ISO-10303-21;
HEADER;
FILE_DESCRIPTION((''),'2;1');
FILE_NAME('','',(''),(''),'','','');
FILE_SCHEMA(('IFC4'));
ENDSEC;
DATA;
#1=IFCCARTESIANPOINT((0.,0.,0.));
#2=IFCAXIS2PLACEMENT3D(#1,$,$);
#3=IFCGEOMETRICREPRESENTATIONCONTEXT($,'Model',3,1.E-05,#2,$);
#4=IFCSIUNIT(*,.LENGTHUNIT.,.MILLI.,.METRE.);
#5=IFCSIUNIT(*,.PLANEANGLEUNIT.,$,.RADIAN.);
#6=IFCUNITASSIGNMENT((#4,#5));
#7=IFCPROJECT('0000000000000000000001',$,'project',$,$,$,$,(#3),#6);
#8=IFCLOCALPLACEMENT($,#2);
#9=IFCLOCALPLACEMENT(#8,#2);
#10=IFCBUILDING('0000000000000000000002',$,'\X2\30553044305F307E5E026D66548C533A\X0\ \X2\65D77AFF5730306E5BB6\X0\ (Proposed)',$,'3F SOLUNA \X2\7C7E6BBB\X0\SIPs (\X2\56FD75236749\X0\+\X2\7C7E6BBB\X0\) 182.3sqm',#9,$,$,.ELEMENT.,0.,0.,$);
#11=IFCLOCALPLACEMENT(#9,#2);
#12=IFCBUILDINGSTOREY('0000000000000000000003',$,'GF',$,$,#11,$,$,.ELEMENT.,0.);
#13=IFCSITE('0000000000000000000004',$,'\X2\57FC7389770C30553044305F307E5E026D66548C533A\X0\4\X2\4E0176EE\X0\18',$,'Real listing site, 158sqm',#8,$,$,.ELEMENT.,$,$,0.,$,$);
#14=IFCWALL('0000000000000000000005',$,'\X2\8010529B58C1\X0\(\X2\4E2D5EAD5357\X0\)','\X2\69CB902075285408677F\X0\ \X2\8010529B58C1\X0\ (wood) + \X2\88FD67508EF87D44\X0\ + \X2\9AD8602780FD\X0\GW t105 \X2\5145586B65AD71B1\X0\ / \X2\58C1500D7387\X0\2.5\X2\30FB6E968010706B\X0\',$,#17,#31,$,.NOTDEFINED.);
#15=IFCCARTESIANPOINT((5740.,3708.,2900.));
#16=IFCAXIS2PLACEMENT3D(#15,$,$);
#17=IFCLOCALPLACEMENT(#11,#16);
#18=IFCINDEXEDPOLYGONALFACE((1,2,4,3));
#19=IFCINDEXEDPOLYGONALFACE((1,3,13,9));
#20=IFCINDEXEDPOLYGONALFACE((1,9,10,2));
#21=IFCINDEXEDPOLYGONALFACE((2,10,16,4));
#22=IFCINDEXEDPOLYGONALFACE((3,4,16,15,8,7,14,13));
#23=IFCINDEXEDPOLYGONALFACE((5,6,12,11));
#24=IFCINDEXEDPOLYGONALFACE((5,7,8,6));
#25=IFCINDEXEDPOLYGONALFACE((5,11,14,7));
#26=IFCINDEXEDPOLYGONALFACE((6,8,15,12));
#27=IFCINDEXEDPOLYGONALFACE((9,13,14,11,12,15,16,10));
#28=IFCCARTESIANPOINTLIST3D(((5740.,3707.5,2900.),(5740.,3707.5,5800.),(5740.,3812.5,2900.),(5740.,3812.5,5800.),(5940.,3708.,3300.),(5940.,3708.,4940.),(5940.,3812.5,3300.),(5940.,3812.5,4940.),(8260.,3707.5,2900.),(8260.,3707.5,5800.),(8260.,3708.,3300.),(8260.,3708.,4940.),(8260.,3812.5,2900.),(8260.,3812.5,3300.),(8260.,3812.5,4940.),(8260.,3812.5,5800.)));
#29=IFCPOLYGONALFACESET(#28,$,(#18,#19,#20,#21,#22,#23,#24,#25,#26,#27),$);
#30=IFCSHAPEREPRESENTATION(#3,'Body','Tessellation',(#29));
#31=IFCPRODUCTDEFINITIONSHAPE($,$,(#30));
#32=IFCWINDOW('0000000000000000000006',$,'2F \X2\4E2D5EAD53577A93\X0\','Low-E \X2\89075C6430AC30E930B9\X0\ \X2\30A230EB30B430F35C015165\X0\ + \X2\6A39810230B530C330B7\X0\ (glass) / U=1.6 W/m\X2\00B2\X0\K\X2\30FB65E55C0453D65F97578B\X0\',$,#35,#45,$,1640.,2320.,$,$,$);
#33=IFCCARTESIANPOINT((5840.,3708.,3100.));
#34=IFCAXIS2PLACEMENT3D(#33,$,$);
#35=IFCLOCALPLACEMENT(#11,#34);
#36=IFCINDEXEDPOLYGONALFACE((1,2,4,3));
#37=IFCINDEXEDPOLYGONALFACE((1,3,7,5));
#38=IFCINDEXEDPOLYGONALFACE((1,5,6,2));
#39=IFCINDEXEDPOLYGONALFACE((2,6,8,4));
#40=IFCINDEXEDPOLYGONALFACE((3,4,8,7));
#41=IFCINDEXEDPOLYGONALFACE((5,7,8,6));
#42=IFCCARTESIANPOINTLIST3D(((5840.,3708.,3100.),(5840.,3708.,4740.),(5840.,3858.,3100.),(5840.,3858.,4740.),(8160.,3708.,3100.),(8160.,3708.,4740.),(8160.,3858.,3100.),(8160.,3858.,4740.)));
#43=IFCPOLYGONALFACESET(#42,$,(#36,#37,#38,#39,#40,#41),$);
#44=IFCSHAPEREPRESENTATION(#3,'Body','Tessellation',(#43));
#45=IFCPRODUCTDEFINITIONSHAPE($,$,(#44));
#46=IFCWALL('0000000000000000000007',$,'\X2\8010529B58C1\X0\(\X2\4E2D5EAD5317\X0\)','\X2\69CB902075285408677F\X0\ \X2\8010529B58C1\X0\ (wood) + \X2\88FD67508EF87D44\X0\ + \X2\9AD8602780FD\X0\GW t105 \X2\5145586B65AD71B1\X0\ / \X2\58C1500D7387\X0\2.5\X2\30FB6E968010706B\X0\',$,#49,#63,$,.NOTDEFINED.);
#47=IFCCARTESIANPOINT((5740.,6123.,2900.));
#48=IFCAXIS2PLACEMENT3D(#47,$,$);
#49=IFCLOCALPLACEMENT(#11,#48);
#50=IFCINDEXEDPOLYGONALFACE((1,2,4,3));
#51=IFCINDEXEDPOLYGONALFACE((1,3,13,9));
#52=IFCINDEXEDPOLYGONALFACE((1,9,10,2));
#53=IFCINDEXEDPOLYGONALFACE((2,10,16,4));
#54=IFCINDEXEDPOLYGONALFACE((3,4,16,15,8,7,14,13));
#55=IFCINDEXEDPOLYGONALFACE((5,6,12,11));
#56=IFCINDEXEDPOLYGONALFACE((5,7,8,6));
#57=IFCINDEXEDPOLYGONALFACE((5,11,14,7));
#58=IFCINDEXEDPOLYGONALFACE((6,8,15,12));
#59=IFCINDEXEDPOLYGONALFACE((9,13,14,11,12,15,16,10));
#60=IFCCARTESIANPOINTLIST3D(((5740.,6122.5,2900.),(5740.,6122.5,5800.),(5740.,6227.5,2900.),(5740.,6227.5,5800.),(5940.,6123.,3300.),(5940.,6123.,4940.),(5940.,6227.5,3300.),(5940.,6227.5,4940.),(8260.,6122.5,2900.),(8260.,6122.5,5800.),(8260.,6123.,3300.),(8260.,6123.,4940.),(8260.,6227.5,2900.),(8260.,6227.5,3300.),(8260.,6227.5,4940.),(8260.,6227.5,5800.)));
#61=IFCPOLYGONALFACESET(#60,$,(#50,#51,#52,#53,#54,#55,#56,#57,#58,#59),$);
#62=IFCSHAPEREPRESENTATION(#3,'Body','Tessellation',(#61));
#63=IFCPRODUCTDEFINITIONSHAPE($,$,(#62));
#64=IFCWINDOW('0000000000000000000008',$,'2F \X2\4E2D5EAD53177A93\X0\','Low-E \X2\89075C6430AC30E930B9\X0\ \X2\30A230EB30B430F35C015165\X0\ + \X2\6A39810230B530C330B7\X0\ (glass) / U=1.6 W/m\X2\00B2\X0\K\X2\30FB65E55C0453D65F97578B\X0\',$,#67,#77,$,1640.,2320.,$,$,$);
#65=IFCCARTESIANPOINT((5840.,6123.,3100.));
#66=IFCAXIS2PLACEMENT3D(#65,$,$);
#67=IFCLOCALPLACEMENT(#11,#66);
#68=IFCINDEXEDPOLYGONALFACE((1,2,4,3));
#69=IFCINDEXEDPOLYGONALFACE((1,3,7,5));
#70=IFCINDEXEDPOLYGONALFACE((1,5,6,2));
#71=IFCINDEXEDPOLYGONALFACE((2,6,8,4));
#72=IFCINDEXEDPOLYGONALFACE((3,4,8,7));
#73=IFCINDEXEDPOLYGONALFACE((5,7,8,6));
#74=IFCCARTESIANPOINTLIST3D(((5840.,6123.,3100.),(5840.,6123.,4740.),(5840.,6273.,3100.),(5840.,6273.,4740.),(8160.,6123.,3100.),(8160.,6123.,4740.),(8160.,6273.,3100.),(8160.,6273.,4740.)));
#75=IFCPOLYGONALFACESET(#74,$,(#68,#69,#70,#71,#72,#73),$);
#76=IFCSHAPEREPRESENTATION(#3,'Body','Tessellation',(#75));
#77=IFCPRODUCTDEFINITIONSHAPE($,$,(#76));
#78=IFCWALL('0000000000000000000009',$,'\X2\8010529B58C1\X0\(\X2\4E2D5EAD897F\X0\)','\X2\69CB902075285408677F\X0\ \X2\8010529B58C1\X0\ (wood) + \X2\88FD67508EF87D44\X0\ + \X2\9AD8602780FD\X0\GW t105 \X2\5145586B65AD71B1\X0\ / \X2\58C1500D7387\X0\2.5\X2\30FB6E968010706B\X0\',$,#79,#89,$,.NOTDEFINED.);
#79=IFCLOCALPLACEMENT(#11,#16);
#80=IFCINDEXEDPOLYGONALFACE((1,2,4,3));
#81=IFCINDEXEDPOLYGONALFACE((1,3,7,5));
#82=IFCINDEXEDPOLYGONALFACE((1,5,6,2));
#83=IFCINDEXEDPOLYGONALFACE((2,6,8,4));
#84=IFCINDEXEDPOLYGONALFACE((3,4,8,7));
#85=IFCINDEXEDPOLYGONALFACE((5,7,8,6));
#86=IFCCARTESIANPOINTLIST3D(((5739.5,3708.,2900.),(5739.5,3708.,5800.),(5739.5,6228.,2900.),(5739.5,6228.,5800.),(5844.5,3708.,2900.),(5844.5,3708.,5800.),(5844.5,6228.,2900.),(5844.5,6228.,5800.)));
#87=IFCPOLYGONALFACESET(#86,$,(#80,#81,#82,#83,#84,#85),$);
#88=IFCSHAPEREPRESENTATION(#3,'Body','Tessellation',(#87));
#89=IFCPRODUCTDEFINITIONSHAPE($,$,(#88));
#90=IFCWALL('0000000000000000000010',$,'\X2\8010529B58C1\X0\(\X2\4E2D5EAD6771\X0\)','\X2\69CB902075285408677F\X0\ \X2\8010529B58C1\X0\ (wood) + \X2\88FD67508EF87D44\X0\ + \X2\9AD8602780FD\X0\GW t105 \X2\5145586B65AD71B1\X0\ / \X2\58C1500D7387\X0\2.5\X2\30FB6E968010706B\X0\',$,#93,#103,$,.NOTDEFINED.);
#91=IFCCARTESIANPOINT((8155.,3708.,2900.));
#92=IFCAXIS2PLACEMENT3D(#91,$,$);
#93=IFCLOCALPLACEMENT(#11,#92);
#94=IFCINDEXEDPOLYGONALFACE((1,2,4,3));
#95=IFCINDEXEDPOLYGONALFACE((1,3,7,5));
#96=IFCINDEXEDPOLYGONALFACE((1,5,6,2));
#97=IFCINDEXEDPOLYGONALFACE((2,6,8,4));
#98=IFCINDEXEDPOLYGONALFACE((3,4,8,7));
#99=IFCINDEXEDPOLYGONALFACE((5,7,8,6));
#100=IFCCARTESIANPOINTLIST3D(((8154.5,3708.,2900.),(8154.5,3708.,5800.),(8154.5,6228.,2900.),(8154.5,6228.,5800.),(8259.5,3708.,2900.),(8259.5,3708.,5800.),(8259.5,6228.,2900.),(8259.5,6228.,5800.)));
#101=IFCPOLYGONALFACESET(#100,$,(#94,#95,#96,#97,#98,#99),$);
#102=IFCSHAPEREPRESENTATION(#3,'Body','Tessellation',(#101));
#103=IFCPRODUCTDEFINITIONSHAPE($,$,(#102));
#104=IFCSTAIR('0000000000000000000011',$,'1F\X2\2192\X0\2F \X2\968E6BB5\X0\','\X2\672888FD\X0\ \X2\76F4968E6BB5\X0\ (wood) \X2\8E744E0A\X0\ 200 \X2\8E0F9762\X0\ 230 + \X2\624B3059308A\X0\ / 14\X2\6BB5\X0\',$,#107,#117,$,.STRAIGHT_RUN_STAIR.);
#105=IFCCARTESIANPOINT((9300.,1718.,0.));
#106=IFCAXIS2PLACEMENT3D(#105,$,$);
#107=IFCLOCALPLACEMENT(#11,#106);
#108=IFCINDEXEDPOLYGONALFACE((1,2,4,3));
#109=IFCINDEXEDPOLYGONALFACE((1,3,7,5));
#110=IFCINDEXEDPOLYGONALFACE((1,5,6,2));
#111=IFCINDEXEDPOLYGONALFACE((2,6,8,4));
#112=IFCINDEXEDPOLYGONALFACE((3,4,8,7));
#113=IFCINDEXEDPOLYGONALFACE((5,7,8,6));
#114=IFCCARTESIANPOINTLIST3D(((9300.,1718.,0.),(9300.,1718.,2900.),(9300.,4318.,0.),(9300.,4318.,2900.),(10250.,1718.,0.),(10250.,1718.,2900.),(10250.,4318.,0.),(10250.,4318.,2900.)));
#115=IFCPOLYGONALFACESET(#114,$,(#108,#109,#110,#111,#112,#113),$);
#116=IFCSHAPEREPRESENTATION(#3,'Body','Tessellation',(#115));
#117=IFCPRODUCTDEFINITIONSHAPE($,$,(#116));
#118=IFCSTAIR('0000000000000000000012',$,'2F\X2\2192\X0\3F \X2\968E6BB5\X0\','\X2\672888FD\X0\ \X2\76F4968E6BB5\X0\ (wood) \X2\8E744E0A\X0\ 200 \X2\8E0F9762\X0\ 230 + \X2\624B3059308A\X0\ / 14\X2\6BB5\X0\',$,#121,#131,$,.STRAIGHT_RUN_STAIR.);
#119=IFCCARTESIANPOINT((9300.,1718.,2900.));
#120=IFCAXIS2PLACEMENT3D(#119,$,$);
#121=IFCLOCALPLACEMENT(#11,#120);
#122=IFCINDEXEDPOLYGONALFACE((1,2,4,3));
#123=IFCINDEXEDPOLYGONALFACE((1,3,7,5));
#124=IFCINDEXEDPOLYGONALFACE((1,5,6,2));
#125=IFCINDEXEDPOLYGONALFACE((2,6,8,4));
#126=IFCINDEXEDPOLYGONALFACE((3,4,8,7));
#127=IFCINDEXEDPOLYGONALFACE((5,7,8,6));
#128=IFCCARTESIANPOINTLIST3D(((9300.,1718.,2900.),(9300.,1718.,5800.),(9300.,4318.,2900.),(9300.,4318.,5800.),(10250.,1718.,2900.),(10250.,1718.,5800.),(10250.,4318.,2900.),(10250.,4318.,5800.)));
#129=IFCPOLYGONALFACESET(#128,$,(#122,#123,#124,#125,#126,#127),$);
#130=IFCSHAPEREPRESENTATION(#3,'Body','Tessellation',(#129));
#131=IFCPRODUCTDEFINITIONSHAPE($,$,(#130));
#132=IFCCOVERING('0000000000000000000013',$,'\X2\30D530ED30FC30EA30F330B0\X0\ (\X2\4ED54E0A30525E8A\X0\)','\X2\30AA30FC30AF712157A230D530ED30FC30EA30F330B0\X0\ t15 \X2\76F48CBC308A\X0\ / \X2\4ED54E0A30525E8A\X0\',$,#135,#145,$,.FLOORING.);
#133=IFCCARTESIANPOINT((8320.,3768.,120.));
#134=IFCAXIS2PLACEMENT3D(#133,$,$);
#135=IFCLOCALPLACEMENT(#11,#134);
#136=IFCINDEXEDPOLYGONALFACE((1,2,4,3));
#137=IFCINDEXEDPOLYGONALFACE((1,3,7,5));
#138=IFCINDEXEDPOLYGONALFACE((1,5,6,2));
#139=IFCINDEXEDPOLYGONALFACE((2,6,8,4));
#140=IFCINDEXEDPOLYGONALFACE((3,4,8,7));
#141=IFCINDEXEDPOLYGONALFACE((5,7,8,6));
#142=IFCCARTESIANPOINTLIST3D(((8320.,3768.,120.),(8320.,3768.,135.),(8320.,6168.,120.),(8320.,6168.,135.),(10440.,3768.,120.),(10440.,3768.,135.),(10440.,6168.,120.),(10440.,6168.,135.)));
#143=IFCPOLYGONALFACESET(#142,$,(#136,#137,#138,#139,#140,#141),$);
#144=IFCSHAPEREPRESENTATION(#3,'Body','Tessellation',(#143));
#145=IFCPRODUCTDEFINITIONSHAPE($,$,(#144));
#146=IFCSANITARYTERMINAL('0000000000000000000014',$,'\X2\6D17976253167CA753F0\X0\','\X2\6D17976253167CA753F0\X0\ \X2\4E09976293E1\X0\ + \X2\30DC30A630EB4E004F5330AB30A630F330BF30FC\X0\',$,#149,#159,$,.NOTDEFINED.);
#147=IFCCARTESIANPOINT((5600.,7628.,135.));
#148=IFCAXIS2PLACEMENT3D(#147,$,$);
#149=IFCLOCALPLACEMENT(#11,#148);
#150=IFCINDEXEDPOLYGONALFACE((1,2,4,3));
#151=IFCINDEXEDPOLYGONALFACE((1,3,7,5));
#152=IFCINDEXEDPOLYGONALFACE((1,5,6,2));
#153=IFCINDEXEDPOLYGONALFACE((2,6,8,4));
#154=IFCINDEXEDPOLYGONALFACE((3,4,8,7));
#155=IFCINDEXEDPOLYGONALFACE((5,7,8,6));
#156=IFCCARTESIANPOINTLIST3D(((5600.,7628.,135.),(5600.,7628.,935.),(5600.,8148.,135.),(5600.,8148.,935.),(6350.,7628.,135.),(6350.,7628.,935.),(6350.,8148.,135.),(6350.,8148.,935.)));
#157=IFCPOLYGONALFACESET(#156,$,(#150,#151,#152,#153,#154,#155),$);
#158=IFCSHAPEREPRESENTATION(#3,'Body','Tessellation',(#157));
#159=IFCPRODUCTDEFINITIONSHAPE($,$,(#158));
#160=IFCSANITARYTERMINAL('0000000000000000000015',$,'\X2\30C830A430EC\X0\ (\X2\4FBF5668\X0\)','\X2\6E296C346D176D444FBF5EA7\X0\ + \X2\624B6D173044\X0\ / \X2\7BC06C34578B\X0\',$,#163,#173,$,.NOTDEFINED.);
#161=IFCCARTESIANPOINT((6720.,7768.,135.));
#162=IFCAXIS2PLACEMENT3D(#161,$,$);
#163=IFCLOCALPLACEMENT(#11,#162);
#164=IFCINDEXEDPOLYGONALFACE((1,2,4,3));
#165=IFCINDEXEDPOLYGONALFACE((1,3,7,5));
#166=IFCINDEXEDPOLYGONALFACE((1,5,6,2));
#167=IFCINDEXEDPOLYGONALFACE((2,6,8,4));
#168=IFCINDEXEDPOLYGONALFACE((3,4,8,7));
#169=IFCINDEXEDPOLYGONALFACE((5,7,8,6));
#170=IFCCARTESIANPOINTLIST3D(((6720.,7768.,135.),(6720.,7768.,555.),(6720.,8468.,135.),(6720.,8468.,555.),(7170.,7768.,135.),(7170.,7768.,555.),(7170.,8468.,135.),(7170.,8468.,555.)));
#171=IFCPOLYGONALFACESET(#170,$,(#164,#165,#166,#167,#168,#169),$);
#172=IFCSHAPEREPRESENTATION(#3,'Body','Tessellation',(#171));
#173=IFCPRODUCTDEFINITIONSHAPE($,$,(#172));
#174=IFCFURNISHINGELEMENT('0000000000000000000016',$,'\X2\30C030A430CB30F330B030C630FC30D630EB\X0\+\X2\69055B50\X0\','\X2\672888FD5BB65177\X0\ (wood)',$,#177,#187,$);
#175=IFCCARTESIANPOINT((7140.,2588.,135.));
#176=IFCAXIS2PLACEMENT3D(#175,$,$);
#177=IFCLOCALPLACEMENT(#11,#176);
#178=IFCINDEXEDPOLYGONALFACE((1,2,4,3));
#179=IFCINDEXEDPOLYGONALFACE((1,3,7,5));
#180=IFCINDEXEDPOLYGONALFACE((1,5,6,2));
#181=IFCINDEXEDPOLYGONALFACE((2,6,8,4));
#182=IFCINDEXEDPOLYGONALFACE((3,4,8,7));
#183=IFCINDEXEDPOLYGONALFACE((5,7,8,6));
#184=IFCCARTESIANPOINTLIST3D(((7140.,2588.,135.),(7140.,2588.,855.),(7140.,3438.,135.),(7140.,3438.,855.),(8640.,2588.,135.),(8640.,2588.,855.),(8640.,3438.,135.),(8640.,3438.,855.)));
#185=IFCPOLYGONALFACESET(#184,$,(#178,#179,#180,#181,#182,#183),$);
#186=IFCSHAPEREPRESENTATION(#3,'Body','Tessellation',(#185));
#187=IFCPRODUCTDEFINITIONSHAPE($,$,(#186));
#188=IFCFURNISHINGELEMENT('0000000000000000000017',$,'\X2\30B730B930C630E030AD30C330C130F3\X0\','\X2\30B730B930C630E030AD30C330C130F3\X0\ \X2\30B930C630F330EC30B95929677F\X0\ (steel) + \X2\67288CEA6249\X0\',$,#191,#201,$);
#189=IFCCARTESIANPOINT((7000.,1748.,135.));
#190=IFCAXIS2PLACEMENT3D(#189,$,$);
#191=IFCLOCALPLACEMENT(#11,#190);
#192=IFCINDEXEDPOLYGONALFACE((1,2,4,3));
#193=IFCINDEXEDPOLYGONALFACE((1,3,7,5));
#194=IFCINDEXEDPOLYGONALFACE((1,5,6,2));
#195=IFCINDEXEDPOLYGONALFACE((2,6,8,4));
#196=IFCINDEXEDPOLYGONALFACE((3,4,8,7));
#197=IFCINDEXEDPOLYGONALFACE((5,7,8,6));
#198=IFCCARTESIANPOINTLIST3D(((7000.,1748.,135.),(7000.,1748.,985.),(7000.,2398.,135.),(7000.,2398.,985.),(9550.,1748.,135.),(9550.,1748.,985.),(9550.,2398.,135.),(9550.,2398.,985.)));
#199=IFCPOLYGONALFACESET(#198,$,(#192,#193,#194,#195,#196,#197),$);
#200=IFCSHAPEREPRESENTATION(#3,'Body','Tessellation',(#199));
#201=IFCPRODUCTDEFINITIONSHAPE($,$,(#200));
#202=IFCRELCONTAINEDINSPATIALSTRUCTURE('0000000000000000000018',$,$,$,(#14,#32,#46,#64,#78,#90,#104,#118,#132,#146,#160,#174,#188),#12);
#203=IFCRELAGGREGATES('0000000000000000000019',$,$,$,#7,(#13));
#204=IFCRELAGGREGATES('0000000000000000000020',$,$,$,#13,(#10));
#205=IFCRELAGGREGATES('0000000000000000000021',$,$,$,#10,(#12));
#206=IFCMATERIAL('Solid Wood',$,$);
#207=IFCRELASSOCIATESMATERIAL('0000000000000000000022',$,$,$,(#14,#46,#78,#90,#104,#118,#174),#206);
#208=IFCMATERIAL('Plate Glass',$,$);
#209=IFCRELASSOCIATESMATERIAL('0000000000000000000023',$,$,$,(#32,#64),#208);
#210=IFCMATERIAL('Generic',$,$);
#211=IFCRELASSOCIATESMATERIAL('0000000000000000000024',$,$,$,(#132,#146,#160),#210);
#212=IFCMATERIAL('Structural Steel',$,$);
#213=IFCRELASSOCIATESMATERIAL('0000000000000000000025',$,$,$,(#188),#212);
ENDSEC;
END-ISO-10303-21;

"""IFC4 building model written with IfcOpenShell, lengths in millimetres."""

from ifc_helpers import new_model, si_unit, frame, frame_2d, origin, place, context, project, spatial, rectangle, extrude, material, element, fill, save


model = new_model("IFC4")

# Units and contexts
model_context = context("Model", 3, precision=1e-05, world=origin())
ifc_project = project(units=[si_unit("LENGTHUNIT", "METRE", prefix="MILLI"), si_unit("PLANEANGLEUNIT", "RADIAN")], contexts=[model_context])

# Site, building, storey
site_placement = place(None, origin())
site = spatial("IfcSite", under=ifc_project, at=site_placement, Name="埼玉県さいたま市浦和区4丁目18", ObjectType="Real listing site, 158sqm", CompositionType="ELEMENT", RefElevation=0.0)
building_placement = place(site_placement, origin())
building = spatial("IfcBuilding", under=site, at=building_placement, Name="さいたま市浦和区 旗竿地の家 (Proposed)", ObjectType="3F SOLUNA 籾殻SIPs (国産杉+籾殻) 182.3sqm", CompositionType="ELEMENT", ElevationOfRefHeight=0.0, ElevationOfTerrain=0.0)
storey_placement = place(building_placement, origin())
storey = spatial("IfcBuildingStorey", under=building, at=storey_placement, Name="GF", CompositionType="ELEMENT", Elevation=0.0)

# Shared definitions
ifc_material_1 = material(Name="Solid Wood")

# Shared definitions
ifc_material_2 = material(Name="Plate Glass")

# Walls, openings, windows
wall_1_placement = place(storey_placement, frame((5740.0, 3708.0, 2900.0)))
wall_1 = element("IfcWall", 1, at=wall_1_placement, inside=storey, material=ifc_material_1, Name="耐力壁(中庭南)", Description="構造用合板 耐力壁 (wood) + 製材軸組 + 高性能GW t105 充填断熱 / 壁倍率2.5・準耐火", PredefinedType="NOTDEFINED", context=model_context, shape_type="SweptSolid", body=[
    extrude(rectangle(XDim=2520.0, YDim=105.0, at=frame_2d((1260.0, 52.0))), frame((5740.0, 3708.0, 2900.0)), (0.0, 0.0, 1.0), 2900.0),
])
opening_1_placement = place(storey_placement, frame((5840.0, 3708.0, 3100.0)))
opening_1 = element("IfcOpeningElement", 2, at=opening_1_placement, cuts=wall_1, PredefinedType="NOTDEFINED", context=model_context, shape_type="SweptSolid", body=[
    extrude(rectangle(XDim=2320.0, YDim=150.0, at=frame_2d((1160.0, 75.0))), frame((5840.0, 3708.0, 3100.0)), (0.0, 0.0, 1.0), 1640.0),
])
window_1_placement = place(storey_placement, frame((5840.0, 3708.0, 3100.0)))
window_1 = element("IfcWindow", 3, at=window_1_placement, inside=storey, material=ifc_material_2, Name="2F 中庭南窓", Description="Low-E 複層ガラス アルゴン封入 + 樹脂サッシ (glass) / U=1.6 W/m²K・日射取得型", OverallHeight=1640.0, OverallWidth=2320.0, context=model_context, shape_type="SweptSolid", body=[
    extrude(rectangle(XDim=2320.0, YDim=150.0, at=frame_2d((1160.0, 75.0))), frame((5840.0, 3708.0, 3100.0)), (0.0, 0.0, 1.0), 1640.0),
])
fill(opening_1, window_1)
wall_2_placement = place(storey_placement, frame((5740.0, 6123.0, 2900.0)))
wall_2 = element("IfcWall", 4, at=wall_2_placement, inside=storey, material=ifc_material_1, Name="耐力壁(中庭北)", Description="構造用合板 耐力壁 (wood) + 製材軸組 + 高性能GW t105 充填断熱 / 壁倍率2.5・準耐火", PredefinedType="NOTDEFINED", context=model_context, shape_type="SweptSolid", body=[
    extrude(rectangle(XDim=2520.0, YDim=105.0, at=frame_2d((1260.0, 52.0))), frame((5740.0, 6123.0, 2900.0)), (0.0, 0.0, 1.0), 2900.0),
])
opening_2_placement = place(storey_placement, frame((5840.0, 6123.0, 3100.0)))
opening_2 = element("IfcOpeningElement", 5, at=opening_2_placement, cuts=wall_2, PredefinedType="NOTDEFINED", context=model_context, shape_type="SweptSolid", body=[
    extrude(rectangle(XDim=2320.0, YDim=150.0, at=frame_2d((1160.0, 75.0))), frame((5840.0, 6123.0, 3100.0)), (0.0, 0.0, 1.0), 1640.0),
])
window_2_placement = place(storey_placement, frame((5840.0, 6123.0, 3100.0)))
window_2 = element("IfcWindow", 6, at=window_2_placement, inside=storey, material=ifc_material_2, Name="2F 中庭北窓", Description="Low-E 複層ガラス アルゴン封入 + 樹脂サッシ (glass) / U=1.6 W/m²K・日射取得型", OverallHeight=1640.0, OverallWidth=2320.0, context=model_context, shape_type="SweptSolid", body=[
    extrude(rectangle(XDim=2320.0, YDim=150.0, at=frame_2d((1160.0, 75.0))), frame((5840.0, 6123.0, 3100.0)), (0.0, 0.0, 1.0), 1640.0),
])
fill(opening_2, window_2)

# Walls
wall_3_placement = place(storey_placement, frame((5740.0, 3708.0, 2900.0)))
element("IfcWall", 7, at=wall_3_placement, inside=storey, material=ifc_material_1, Name="耐力壁(中庭西)", Description="構造用合板 耐力壁 (wood) + 製材軸組 + 高性能GW t105 充填断熱 / 壁倍率2.5・準耐火", PredefinedType="NOTDEFINED", context=model_context, shape_type="SweptSolid", body=[
    extrude(rectangle(XDim=105.0, YDim=2520.0, at=frame_2d((52.0, 1260.0))), frame((5740.0, 3708.0, 2900.0)), (0.0, 0.0, 1.0), 2900.0),
])
wall_4_placement = place(storey_placement, frame((8155.0, 3708.0, 2900.0)))
element("IfcWall", 8, at=wall_4_placement, inside=storey, material=ifc_material_1, Name="耐力壁(中庭東)", Description="構造用合板 耐力壁 (wood) + 製材軸組 + 高性能GW t105 充填断熱 / 壁倍率2.5・準耐火", PredefinedType="NOTDEFINED", context=model_context, shape_type="SweptSolid", body=[
    extrude(rectangle(XDim=105.0, YDim=2520.0, at=frame_2d((52.0, 1260.0))), frame((8155.0, 3708.0, 2900.0)), (0.0, 0.0, 1.0), 2900.0),
])

# Stairs
stair_1_placement = place(storey_placement, frame((9300.0, 1718.0, 0.0)))
element("IfcStair", 9, at=stair_1_placement, inside=storey, material=ifc_material_1, Name="1F→2F 階段", Description="木製 直階段 (wood) 蹴上 200 踏面 230 + 手すり / 14段", PredefinedType="STRAIGHT_RUN_STAIR", context=model_context, shape_type="SweptSolid", body=[
    extrude(rectangle(XDim=950.0, YDim=2600.0, at=frame_2d((475.0, 1300.0))), frame((9300.0, 1718.0, 0.0)), (0.0, 0.0, 1.0), 2900.0),
])
stair_2_placement = place(storey_placement, frame((9300.0, 1718.0, 2900.0)))
element("IfcStair", 10, at=stair_2_placement, inside=storey, material=ifc_material_1, Name="2F→3F 階段", Description="木製 直階段 (wood) 蹴上 200 踏面 230 + 手すり / 14段", PredefinedType="STRAIGHT_RUN_STAIR", context=model_context, shape_type="SweptSolid", body=[
    extrude(rectangle(XDim=950.0, YDim=2600.0, at=frame_2d((475.0, 1300.0))), frame((9300.0, 1718.0, 2900.0)), (0.0, 0.0, 1.0), 2900.0),
])

# Covering
ifc_material_3 = material(Name="Generic")
covering_placement = place(storey_placement, frame((8320.0, 3768.0, 120.0)))
element("IfcCovering", 11, at=covering_placement, inside=storey, material=ifc_material_3, Name="フローリング (仕上げ床)", Description="オーク無垢フローリング t15 直貼り / 仕上げ床", PredefinedType="FLOORING", context=model_context, shape_type="SweptSolid", body=[
    extrude(rectangle(XDim=2120.0, YDim=2400.0, at=frame_2d((1060.0, 1200.0))), frame((8320.0, 3768.0, 120.0)), (0.0, 0.0, 1.0), 15.0),
])

# Sanitary terminals
sanitary_terminal_1_placement = place(storey_placement, frame((5600.0, 7628.0, 135.0)))
element("IfcSanitaryTerminal", 12, at=sanitary_terminal_1_placement, inside=storey, material=ifc_material_3, Name="洗面化粧台", Description="洗面化粧台 三面鏡 + ボウル一体カウンター", PredefinedType="NOTDEFINED", context=model_context, shape_type="SweptSolid", body=[
    extrude(rectangle(XDim=750.0, YDim=520.0, at=frame_2d((375.0, 260.0))), frame((5600.0, 7628.0, 135.0)), (0.0, 0.0, 1.0), 800.0),
])
sanitary_terminal_2_placement = place(storey_placement, frame((6720.0, 7768.0, 135.0)))
element("IfcSanitaryTerminal", 13, at=sanitary_terminal_2_placement, inside=storey, material=ifc_material_3, Name="トイレ (便器)", Description="温水洗浄便座 + 手洗い / 節水型", PredefinedType="NOTDEFINED", context=model_context, shape_type="SweptSolid", body=[
    extrude(rectangle(XDim=450.0, YDim=700.0, at=frame_2d((225.0, 350.0))), frame((6720.0, 7768.0, 135.0)), (0.0, 0.0, 1.0), 420.0),
])

# Furnishing elements
furnishing_1_placement = place(storey_placement, frame((7140.0, 2588.0, 135.0)))
element("IfcFurnishingElement", 14, at=furnishing_1_placement, inside=storey, material=ifc_material_1, Name="ダイニングテーブル+椅子", Description="木製家具 (wood)", context=model_context, shape_type="SweptSolid", body=[
    extrude(rectangle(XDim=1500.0, YDim=850.0, at=frame_2d((750.0, 425.0))), frame((7140.0, 2588.0, 135.0)), (0.0, 0.0, 1.0), 720.0),
])
ifc_material_4 = material(Name="Structural Steel")
furnishing_2_placement = place(storey_placement, frame((7000.0, 1748.0, 135.0)))
element("IfcFurnishingElement", 15, at=furnishing_2_placement, inside=storey, material=ifc_material_4, Name="システムキッチン", Description="システムキッチン ステンレス天板 (steel) + 木質扉", context=model_context, shape_type="SweptSolid", body=[
    extrude(rectangle(XDim=2550.0, YDim=650.0, at=frame_2d((1275.0, 325.0))), frame((7000.0, 1748.0, 135.0)), (0.0, 0.0, 1.0), 850.0),
])

save(model, "model.ifc")
